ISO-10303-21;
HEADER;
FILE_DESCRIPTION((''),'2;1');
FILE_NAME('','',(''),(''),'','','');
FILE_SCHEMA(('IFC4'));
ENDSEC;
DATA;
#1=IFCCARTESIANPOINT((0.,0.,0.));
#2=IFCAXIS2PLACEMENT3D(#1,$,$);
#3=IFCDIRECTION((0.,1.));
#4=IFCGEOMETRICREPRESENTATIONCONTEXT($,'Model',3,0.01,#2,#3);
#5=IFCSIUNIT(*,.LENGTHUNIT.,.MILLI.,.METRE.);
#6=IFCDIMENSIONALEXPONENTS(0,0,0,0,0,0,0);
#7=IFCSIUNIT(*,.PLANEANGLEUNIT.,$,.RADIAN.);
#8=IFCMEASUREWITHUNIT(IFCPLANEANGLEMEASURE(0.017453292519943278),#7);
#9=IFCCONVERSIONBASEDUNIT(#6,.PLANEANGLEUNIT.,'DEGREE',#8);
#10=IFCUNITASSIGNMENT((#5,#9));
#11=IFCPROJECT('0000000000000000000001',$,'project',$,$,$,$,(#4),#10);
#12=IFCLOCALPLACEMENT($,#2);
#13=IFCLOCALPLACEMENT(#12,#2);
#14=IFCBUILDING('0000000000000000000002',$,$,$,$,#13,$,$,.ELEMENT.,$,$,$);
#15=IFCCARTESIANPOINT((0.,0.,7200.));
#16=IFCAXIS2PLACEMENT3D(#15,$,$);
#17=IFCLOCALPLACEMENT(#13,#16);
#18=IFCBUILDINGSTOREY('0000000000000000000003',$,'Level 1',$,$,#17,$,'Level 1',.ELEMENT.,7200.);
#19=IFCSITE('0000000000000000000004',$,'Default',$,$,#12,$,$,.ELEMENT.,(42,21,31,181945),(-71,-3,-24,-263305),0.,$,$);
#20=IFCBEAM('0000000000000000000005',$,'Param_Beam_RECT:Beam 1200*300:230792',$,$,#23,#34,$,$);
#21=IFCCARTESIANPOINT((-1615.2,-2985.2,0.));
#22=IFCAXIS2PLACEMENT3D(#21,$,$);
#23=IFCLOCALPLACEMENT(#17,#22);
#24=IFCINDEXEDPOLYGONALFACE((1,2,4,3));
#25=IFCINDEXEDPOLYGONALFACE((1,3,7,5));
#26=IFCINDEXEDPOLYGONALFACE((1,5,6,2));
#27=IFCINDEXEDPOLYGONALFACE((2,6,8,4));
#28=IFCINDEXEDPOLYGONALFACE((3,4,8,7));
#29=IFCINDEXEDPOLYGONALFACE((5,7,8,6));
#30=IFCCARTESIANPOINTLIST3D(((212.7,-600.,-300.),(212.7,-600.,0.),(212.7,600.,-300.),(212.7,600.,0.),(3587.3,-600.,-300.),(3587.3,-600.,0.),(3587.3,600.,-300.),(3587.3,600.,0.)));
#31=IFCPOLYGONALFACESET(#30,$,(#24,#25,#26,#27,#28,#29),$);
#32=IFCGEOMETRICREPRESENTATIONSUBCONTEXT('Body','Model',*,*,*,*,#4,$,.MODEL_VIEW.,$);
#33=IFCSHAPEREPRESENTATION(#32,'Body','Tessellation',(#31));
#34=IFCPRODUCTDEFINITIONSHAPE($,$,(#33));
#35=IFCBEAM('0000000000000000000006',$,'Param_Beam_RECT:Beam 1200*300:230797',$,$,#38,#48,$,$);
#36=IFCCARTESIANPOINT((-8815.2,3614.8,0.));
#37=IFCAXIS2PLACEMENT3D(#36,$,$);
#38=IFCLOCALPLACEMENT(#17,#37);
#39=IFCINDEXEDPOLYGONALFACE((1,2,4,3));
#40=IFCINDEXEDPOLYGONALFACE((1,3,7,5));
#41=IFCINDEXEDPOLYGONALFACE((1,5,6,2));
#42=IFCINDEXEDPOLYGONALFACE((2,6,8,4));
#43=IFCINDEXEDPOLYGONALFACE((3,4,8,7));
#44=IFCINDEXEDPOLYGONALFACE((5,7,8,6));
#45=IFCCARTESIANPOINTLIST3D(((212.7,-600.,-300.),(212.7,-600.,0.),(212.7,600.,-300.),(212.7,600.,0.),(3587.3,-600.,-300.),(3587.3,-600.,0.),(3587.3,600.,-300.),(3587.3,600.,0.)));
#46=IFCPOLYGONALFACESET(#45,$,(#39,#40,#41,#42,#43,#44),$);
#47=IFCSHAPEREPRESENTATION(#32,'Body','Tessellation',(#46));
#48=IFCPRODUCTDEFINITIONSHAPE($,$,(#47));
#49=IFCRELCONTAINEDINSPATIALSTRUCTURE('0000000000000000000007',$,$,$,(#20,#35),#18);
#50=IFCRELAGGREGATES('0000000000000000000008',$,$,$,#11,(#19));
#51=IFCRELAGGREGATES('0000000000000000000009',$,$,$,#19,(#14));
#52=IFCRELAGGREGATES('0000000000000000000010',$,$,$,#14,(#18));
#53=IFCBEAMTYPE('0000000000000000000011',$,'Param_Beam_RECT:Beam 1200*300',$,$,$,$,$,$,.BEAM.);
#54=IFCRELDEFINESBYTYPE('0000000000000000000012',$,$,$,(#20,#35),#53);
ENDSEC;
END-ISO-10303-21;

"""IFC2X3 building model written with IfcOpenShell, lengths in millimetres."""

from ifc_helpers import new_model, entity, si_unit, converted_unit, direction, frame, frame_2d, origin, place, context, subcontext, project, spatial, rectangle, extrude, type_object, element, save


model = new_model("IFC2X3")

# Units and contexts
model_context = context("Model", 3, precision=0.01, world=origin(), true_north=direction((0.0, 1.0)))
body_context = subcontext(model_context, "Body", "Model", "MODEL_VIEW")
ifc_project = project(units=[si_unit("LENGTHUNIT", "METRE", prefix="MILLI"), converted_unit("PLANEANGLEUNIT", "DEGREE", entity("IfcPlaneAngleMeasure", 0.017453292519943278), si_unit("PLANEANGLEUNIT", "RADIAN"), dimensions=[0, 0, 0, 0, 0, 0, 0])], contexts=[model_context])

# Site, building, storey
site_placement = place(None, origin())
site = spatial("IfcSite", under=ifc_project, at=site_placement, Name="Default", CompositionType="ELEMENT", RefLatitude=(42, 21, 31, 181945), RefLongitude=(-71, -3, -24, -263305), RefElevation=0.0)
building_placement = place(site_placement, origin())
building = spatial("IfcBuilding", under=site, at=building_placement, CompositionType="ELEMENT")
storey_placement = place(building_placement, frame((0.0, 0.0, 7200.0)))
storey = spatial("IfcBuildingStorey", under=building, at=storey_placement, Name="Level 1", LongName="Level 1", CompositionType="ELEMENT", Elevation=7200.0)

# Beams
beam_type_1 = type_object("IfcBeamType", Name="Param_Beam_RECT:Beam 1200*300", PredefinedType="BEAM")
beam_1_placement = place(storey_placement, frame((-1615.2, -2985.2, 0.0)))
element("IfcBeam", 1, at=beam_1_placement, inside=storey, type_object=beam_type_1, Name="Param_Beam_RECT:Beam 1200*300:230792", context=body_context, shape_type="SweptSolid", body=[
    extrude(rectangle(XDim=300.0, YDim=1200.0, at=frame_2d((0.0, 0.0), x_axis=(1.0, 0.0))), frame((212.7, 0.0, -150.0), z_axis=(1.0, 0.0, 0.0), x_axis=(0.0, 0.0, -1.0)), (0.0, 0.0, 1.0), 3374.6),
])
beam_2_placement = place(storey_placement, frame((-8815.2, 3614.8, 0.0)))
element("IfcBeam", 2, at=beam_2_placement, inside=storey, type_object=beam_type_1, Name="Param_Beam_RECT:Beam 1200*300:230797", context=body_context, shape_type="SweptSolid", body=[
    extrude(rectangle(XDim=300.0, YDim=1200.0, at=frame_2d((0.0, 0.0), x_axis=(1.0, 0.0))), frame((212.7, 0.0, -150.0), z_axis=(1.0, 0.0, 0.0), x_axis=(0.0, 0.0, -1.0)), (0.0, 0.0, 1.0), 3374.6),
])

save(model, "model.ifc")
